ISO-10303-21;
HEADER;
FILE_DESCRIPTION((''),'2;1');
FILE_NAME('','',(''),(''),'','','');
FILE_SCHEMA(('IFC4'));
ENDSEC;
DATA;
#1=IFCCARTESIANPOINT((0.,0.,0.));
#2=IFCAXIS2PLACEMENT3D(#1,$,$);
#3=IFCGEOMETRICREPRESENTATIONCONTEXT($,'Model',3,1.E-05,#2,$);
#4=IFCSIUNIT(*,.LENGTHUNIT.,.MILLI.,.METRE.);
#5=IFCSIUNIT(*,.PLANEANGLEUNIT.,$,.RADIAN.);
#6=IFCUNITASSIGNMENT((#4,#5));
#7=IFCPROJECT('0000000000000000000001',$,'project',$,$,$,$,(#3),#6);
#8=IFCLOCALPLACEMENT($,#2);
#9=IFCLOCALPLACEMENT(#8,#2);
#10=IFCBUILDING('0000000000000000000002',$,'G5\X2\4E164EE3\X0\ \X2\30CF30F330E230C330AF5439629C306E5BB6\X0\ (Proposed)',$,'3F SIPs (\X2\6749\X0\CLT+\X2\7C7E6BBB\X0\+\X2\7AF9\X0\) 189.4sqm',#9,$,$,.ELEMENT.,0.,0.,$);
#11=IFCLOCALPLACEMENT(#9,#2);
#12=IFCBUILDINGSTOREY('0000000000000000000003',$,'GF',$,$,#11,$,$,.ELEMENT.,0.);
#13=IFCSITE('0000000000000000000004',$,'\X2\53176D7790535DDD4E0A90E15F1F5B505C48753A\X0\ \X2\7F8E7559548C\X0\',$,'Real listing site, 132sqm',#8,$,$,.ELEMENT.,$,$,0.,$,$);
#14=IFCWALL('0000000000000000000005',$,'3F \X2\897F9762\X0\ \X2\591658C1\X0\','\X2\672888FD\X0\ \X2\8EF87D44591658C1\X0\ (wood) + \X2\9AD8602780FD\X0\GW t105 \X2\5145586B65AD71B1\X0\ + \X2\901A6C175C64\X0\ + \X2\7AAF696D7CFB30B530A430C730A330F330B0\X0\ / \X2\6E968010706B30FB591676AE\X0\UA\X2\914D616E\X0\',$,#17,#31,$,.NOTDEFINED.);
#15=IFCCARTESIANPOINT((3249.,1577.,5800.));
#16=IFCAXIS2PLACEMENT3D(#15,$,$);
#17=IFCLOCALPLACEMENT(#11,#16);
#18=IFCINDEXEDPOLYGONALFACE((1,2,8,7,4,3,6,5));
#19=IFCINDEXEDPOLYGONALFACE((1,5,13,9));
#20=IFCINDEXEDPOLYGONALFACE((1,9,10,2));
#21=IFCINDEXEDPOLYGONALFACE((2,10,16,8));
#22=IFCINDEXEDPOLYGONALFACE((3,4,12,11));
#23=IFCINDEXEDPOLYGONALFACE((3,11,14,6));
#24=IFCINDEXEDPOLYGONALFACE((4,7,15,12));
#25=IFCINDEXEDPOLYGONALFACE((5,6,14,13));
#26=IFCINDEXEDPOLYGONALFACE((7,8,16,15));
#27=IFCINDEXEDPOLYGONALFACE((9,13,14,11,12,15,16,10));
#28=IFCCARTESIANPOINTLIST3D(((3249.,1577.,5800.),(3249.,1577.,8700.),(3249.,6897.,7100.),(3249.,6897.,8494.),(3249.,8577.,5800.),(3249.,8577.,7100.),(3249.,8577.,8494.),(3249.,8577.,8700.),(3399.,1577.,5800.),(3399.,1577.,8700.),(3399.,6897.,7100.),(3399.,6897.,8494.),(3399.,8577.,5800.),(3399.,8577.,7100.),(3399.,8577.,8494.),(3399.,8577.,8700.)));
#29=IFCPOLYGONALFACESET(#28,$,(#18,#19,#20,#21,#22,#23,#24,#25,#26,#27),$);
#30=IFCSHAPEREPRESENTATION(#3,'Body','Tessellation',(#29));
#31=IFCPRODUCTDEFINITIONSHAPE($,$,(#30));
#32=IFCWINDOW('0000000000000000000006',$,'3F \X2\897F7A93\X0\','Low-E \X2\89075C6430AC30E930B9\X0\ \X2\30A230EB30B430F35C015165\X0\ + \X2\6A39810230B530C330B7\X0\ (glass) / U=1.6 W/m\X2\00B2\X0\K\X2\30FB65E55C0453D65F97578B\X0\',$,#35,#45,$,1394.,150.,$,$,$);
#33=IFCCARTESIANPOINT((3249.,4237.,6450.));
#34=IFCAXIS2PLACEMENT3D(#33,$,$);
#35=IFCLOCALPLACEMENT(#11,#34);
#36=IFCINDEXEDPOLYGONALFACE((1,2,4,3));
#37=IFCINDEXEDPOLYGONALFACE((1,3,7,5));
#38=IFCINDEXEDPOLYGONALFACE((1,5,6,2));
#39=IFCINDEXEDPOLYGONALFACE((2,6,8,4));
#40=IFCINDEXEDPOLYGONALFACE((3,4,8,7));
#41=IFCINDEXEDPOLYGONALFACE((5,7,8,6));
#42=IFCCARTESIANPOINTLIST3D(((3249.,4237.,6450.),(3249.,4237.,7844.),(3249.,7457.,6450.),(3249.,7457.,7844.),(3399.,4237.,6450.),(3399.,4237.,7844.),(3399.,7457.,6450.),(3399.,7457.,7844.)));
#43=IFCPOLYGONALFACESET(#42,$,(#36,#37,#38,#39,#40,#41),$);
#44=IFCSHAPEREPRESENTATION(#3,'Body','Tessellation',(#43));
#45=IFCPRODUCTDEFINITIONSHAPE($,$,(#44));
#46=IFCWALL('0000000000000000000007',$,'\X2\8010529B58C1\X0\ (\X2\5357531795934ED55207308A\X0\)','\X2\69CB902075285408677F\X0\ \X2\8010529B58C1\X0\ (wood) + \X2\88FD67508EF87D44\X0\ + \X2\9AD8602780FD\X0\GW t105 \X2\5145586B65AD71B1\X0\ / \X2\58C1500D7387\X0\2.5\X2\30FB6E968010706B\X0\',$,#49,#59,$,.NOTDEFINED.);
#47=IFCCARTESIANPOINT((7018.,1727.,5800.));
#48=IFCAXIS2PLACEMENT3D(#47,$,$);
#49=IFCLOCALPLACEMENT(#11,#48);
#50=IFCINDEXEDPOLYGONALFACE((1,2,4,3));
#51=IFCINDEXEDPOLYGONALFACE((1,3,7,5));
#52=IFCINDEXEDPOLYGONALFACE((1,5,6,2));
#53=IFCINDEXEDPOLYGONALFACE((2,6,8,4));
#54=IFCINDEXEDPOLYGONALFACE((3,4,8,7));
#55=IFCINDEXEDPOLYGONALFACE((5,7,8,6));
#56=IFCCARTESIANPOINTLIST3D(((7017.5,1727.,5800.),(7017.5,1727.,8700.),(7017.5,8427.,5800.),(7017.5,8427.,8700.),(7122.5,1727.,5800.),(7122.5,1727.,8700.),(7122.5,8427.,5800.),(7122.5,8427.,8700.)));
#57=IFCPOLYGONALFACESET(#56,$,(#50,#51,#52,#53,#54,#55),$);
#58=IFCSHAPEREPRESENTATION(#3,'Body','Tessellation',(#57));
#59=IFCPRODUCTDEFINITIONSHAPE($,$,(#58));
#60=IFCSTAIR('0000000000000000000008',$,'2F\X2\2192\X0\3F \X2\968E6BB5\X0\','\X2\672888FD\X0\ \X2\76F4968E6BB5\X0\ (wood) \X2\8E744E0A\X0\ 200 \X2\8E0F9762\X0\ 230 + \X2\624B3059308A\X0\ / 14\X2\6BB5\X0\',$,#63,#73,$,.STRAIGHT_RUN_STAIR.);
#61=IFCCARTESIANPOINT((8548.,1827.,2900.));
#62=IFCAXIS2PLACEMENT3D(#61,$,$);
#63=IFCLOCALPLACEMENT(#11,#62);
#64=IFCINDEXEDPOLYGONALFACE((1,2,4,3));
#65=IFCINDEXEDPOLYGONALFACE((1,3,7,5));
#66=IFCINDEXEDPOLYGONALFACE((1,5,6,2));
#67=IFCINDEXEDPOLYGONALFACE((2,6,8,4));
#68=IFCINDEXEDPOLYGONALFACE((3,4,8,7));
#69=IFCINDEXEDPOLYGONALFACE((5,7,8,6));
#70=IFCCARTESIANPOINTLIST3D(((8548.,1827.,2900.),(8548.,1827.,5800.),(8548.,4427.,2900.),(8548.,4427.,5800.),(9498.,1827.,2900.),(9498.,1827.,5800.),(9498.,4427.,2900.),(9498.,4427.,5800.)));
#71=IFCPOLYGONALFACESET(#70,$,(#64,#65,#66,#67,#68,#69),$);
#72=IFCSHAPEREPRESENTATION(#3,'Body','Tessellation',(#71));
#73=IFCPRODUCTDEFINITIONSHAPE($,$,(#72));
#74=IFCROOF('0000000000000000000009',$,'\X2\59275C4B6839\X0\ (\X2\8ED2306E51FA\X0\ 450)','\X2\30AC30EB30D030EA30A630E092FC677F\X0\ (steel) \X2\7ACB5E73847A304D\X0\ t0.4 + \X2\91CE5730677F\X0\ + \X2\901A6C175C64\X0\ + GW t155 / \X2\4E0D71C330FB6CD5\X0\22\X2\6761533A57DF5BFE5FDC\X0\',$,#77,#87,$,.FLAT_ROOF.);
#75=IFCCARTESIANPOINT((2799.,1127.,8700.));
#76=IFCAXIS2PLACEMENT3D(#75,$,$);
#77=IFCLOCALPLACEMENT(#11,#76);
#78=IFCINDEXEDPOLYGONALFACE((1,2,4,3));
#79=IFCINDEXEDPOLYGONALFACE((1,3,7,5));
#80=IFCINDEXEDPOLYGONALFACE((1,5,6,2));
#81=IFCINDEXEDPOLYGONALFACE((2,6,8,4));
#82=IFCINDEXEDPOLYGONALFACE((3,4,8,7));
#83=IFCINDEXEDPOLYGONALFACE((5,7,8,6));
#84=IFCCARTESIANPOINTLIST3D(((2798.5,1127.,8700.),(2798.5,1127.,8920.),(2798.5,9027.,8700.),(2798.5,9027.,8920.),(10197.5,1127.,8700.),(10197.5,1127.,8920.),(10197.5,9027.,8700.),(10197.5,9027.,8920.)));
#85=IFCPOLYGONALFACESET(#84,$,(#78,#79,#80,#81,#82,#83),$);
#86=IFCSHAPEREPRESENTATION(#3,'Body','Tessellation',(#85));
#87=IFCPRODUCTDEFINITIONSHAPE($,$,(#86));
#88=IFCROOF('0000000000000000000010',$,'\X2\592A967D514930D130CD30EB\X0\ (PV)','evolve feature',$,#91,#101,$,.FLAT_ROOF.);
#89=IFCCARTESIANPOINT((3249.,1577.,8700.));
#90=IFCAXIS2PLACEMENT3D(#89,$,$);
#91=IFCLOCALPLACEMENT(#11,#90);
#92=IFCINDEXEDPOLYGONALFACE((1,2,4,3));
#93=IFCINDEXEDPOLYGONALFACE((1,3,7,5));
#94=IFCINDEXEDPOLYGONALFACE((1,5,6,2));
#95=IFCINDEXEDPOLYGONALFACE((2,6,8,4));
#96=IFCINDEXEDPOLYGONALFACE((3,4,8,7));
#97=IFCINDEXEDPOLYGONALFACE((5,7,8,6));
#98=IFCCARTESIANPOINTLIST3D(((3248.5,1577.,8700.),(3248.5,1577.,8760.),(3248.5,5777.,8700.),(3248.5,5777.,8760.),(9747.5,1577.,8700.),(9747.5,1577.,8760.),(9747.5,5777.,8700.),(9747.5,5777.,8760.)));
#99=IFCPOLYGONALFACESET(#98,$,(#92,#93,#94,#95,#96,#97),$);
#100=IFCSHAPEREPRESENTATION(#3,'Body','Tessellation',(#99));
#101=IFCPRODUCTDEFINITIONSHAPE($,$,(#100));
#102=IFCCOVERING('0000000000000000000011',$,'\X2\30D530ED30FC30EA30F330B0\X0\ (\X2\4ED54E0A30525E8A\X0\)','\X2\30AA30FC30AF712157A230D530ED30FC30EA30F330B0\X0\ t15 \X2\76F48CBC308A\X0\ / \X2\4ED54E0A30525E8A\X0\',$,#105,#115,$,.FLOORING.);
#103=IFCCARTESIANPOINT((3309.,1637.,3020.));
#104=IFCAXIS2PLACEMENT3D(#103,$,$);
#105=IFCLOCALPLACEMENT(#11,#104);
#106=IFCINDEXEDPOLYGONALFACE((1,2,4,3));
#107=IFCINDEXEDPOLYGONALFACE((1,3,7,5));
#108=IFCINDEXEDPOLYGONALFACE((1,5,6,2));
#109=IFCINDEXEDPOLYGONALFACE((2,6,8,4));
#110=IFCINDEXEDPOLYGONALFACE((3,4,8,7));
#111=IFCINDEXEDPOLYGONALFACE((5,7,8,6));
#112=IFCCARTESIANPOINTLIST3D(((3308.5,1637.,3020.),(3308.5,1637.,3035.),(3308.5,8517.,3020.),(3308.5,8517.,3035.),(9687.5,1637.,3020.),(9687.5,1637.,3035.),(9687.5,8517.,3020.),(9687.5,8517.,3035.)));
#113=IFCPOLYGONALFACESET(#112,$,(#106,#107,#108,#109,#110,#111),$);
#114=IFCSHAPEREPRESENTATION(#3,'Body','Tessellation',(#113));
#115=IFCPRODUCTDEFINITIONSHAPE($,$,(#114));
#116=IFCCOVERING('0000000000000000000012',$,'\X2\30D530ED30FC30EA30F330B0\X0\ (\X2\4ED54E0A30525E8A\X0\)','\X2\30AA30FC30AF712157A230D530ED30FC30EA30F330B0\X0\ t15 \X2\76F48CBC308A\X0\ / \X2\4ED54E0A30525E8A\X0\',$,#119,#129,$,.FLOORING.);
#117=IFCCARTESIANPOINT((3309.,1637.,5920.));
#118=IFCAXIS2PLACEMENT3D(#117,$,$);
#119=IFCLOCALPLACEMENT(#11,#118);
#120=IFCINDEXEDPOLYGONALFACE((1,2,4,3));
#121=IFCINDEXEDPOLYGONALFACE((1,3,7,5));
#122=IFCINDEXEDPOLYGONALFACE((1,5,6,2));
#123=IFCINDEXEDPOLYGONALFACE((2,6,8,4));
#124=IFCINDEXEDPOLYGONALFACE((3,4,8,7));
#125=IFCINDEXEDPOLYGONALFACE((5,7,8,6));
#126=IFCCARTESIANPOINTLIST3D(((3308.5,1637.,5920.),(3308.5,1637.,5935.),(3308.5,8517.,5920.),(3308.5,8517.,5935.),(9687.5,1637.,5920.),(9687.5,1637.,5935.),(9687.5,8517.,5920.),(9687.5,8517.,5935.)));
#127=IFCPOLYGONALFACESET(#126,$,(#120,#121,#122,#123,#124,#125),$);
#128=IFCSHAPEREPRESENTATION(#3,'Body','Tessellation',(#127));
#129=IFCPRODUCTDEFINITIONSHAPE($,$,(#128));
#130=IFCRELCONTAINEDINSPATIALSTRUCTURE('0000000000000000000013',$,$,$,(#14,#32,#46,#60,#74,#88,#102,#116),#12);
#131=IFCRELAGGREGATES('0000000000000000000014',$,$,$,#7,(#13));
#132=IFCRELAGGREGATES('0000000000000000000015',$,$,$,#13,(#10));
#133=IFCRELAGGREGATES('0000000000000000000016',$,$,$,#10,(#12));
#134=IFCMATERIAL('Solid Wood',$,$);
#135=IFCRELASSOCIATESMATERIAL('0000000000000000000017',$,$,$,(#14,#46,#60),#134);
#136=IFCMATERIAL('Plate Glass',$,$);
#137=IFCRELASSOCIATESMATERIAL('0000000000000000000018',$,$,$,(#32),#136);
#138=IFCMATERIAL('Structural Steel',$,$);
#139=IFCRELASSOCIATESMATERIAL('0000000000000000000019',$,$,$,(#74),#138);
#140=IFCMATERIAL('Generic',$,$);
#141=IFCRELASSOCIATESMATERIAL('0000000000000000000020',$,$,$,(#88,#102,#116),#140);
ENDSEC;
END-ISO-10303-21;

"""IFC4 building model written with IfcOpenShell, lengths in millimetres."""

from ifc_helpers import new_model, si_unit, frame, frame_2d, origin, place, context, project, spatial, rectangle, extrude, material, element, fill, save


model = new_model("IFC4")

# Units and contexts
model_context = context("Model", 3, precision=1e-05, world=origin())
ifc_project = project(units=[si_unit("LENGTHUNIT", "METRE", prefix="MILLI"), si_unit("PLANEANGLEUNIT", "RADIAN")], contexts=[model_context])

# Site, building, storey
site_placement = place(None, origin())
site = spatial("IfcSite", under=ifc_project, at=site_placement, Name="北海道川上郡弟子屈町 美留和", ObjectType="Real listing site, 132sqm", CompositionType="ELEMENT", RefElevation=0.0)
building_placement = place(site_placement, origin())
building = spatial("IfcBuilding", under=site, at=building_placement, Name="G5世代 ハンモック吹抜の家 (Proposed)", ObjectType="3F SIPs (杉CLT+籾殻+竹) 189.4sqm", CompositionType="ELEMENT", ElevationOfRefHeight=0.0, ElevationOfTerrain=0.0)
storey_placement = place(building_placement, origin())
storey = spatial("IfcBuildingStorey", under=building, at=storey_placement, Name="GF", CompositionType="ELEMENT", Elevation=0.0)

# Shared definitions
ifc_material_1 = material(Name="Solid Wood")

# Shared definitions
ifc_material_2 = material(Name="Plate Glass")

# Shared definitions
ifc_material_3 = material(Name="Generic")

# Wall, opening, window
wall_1_placement = place(storey_placement, frame((3249.0, 1577.0, 5800.0)))
wall_1 = element("IfcWall", 1, at=wall_1_placement, inside=storey, material=ifc_material_1, Name="3F 西面 外壁", Description="木製 軸組外壁 (wood) + 高性能GW t105 充填断熱 + 通気層 + 窯業系サイディング / 準耐火・外皮UA配慮", PredefinedType="NOTDEFINED", context=model_context, shape_type="SweptSolid", body=[
    extrude(rectangle(XDim=150.0, YDim=7000.0, at=frame_2d((75.0, 3500.0))), frame((3249.0, 1577.0, 5800.0)), (0.0, 0.0, 1.0), 2900.0),
])
opening_1_placement = place(storey_placement, frame((3249.0, 4237.0, 6450.0)))
opening_1 = element("IfcOpeningElement", 2, at=opening_1_placement, cuts=wall_1, PredefinedType="NOTDEFINED", context=model_context, shape_type="SweptSolid", body=[
    extrude(rectangle(XDim=150.0, YDim=3220.0, at=frame_2d((75.0, 1610.0))), frame((3249.0, 4237.0, 6450.0)), (0.0, 0.0, 1.0), 1394.0),
])
window_1_placement = place(storey_placement, frame((3249.0, 4237.0, 6450.0)))
window_1 = element("IfcWindow", 3, at=window_1_placement, inside=storey, material=ifc_material_2, Name="3F 西窓", Description="Low-E 複層ガラス アルゴン封入 + 樹脂サッシ (glass) / U=1.6 W/m²K・日射取得型", OverallHeight=1394.0, OverallWidth=150.0, context=model_context, shape_type="SweptSolid", body=[
    extrude(rectangle(XDim=150.0, YDim=3220.0, at=frame_2d((75.0, 1610.0))), frame((3249.0, 4237.0, 6450.0)), (0.0, 0.0, 1.0), 1394.0),
])
fill(opening_1, window_1)

# Wall
wall_2_placement = place(storey_placement, frame((7018.0, 1727.0, 5800.0)))
element("IfcWall", 4, at=wall_2_placement, inside=storey, material=ifc_material_1, Name="耐力壁 (南北間仕切り)", Description="構造用合板 耐力壁 (wood) + 製材軸組 + 高性能GW t105 充填断熱 / 壁倍率2.5・準耐火", PredefinedType="NOTDEFINED", context=model_context, shape_type="SweptSolid", body=[
    extrude(rectangle(XDim=105.0, YDim=6700.0, at=frame_2d((52.0, 3350.0))), frame((7018.0, 1727.0, 5800.0)), (0.0, 0.0, 1.0), 2900.0),
])

# Stair
stair_placement = place(storey_placement, frame((8548.0, 1827.0, 2900.0)))
element("IfcStair", 5, at=stair_placement, inside=storey, material=ifc_material_1, Name="2F→3F 階段", Description="木製 直階段 (wood) 蹴上 200 踏面 230 + 手すり / 14段", PredefinedType="STRAIGHT_RUN_STAIR", context=model_context, shape_type="SweptSolid", body=[
    extrude(rectangle(XDim=950.0, YDim=2600.0, at=frame_2d((475.0, 1300.0))), frame((8548.0, 1827.0, 2900.0)), (0.0, 0.0, 1.0), 2900.0),
])

# Roofs
ifc_material_4 = material(Name="Structural Steel")
roof_1_placement = place(storey_placement, frame((2799.0, 1127.0, 8700.0)))
element("IfcRoof", 6, at=roof_1_placement, inside=storey, material=ifc_material_4, Name="大屋根 (軒の出 450)", Description="ガルバリウム鋼板 (steel) 立平葺き t0.4 + 野地板 + 通気層 + GW t155 / 不燃・法22条区域対応", PredefinedType="FLAT_ROOF", context=model_context, shape_type="SweptSolid", body=[
    extrude(rectangle(XDim=7399.0, YDim=7900.0, at=frame_2d((3699.0, 3950.0))), frame((2799.0, 1127.0, 8700.0)), (0.0, 0.0, 1.0), 220.0),
])
roof_2_placement = place(storey_placement, frame((3249.0, 1577.0, 8700.0)))
element("IfcRoof", 7, at=roof_2_placement, inside=storey, material=ifc_material_3, Name="太陽光パネル (PV)", Description="evolve feature", PredefinedType="FLAT_ROOF", context=model_context, shape_type="SweptSolid", body=[
    extrude(rectangle(XDim=6499.0, YDim=4200.0, at=frame_2d((3249.0, 2100.0))), frame((3249.0, 1577.0, 8700.0)), (0.0, 0.0, 1.0), 60.0),
])

# Coverings
covering_1_placement = place(storey_placement, frame((3309.0, 1637.0, 3020.0)))
element("IfcCovering", 8, at=covering_1_placement, inside=storey, material=ifc_material_3, Name="フローリング (仕上げ床)", Description="オーク無垢フローリング t15 直貼り / 仕上げ床", PredefinedType="FLOORING", context=model_context, shape_type="SweptSolid", body=[
    extrude(rectangle(XDim=6379.0, YDim=6880.0, at=frame_2d((3189.0, 3440.0))), frame((3309.0, 1637.0, 3020.0)), (0.0, 0.0, 1.0), 15.0),
])
covering_2_placement = place(storey_placement, frame((3309.0, 1637.0, 5920.0)))
element("IfcCovering", 9, at=covering_2_placement, inside=storey, material=ifc_material_3, Name="フローリング (仕上げ床)", Description="オーク無垢フローリング t15 直貼り / 仕上げ床", PredefinedType="FLOORING", context=model_context, shape_type="SweptSolid", body=[
    extrude(rectangle(XDim=6379.0, YDim=6880.0, at=frame_2d((3189.0, 3440.0))), frame((3309.0, 1637.0, 5920.0)), (0.0, 0.0, 1.0), 15.0),
])

save(model, "model.ifc")
